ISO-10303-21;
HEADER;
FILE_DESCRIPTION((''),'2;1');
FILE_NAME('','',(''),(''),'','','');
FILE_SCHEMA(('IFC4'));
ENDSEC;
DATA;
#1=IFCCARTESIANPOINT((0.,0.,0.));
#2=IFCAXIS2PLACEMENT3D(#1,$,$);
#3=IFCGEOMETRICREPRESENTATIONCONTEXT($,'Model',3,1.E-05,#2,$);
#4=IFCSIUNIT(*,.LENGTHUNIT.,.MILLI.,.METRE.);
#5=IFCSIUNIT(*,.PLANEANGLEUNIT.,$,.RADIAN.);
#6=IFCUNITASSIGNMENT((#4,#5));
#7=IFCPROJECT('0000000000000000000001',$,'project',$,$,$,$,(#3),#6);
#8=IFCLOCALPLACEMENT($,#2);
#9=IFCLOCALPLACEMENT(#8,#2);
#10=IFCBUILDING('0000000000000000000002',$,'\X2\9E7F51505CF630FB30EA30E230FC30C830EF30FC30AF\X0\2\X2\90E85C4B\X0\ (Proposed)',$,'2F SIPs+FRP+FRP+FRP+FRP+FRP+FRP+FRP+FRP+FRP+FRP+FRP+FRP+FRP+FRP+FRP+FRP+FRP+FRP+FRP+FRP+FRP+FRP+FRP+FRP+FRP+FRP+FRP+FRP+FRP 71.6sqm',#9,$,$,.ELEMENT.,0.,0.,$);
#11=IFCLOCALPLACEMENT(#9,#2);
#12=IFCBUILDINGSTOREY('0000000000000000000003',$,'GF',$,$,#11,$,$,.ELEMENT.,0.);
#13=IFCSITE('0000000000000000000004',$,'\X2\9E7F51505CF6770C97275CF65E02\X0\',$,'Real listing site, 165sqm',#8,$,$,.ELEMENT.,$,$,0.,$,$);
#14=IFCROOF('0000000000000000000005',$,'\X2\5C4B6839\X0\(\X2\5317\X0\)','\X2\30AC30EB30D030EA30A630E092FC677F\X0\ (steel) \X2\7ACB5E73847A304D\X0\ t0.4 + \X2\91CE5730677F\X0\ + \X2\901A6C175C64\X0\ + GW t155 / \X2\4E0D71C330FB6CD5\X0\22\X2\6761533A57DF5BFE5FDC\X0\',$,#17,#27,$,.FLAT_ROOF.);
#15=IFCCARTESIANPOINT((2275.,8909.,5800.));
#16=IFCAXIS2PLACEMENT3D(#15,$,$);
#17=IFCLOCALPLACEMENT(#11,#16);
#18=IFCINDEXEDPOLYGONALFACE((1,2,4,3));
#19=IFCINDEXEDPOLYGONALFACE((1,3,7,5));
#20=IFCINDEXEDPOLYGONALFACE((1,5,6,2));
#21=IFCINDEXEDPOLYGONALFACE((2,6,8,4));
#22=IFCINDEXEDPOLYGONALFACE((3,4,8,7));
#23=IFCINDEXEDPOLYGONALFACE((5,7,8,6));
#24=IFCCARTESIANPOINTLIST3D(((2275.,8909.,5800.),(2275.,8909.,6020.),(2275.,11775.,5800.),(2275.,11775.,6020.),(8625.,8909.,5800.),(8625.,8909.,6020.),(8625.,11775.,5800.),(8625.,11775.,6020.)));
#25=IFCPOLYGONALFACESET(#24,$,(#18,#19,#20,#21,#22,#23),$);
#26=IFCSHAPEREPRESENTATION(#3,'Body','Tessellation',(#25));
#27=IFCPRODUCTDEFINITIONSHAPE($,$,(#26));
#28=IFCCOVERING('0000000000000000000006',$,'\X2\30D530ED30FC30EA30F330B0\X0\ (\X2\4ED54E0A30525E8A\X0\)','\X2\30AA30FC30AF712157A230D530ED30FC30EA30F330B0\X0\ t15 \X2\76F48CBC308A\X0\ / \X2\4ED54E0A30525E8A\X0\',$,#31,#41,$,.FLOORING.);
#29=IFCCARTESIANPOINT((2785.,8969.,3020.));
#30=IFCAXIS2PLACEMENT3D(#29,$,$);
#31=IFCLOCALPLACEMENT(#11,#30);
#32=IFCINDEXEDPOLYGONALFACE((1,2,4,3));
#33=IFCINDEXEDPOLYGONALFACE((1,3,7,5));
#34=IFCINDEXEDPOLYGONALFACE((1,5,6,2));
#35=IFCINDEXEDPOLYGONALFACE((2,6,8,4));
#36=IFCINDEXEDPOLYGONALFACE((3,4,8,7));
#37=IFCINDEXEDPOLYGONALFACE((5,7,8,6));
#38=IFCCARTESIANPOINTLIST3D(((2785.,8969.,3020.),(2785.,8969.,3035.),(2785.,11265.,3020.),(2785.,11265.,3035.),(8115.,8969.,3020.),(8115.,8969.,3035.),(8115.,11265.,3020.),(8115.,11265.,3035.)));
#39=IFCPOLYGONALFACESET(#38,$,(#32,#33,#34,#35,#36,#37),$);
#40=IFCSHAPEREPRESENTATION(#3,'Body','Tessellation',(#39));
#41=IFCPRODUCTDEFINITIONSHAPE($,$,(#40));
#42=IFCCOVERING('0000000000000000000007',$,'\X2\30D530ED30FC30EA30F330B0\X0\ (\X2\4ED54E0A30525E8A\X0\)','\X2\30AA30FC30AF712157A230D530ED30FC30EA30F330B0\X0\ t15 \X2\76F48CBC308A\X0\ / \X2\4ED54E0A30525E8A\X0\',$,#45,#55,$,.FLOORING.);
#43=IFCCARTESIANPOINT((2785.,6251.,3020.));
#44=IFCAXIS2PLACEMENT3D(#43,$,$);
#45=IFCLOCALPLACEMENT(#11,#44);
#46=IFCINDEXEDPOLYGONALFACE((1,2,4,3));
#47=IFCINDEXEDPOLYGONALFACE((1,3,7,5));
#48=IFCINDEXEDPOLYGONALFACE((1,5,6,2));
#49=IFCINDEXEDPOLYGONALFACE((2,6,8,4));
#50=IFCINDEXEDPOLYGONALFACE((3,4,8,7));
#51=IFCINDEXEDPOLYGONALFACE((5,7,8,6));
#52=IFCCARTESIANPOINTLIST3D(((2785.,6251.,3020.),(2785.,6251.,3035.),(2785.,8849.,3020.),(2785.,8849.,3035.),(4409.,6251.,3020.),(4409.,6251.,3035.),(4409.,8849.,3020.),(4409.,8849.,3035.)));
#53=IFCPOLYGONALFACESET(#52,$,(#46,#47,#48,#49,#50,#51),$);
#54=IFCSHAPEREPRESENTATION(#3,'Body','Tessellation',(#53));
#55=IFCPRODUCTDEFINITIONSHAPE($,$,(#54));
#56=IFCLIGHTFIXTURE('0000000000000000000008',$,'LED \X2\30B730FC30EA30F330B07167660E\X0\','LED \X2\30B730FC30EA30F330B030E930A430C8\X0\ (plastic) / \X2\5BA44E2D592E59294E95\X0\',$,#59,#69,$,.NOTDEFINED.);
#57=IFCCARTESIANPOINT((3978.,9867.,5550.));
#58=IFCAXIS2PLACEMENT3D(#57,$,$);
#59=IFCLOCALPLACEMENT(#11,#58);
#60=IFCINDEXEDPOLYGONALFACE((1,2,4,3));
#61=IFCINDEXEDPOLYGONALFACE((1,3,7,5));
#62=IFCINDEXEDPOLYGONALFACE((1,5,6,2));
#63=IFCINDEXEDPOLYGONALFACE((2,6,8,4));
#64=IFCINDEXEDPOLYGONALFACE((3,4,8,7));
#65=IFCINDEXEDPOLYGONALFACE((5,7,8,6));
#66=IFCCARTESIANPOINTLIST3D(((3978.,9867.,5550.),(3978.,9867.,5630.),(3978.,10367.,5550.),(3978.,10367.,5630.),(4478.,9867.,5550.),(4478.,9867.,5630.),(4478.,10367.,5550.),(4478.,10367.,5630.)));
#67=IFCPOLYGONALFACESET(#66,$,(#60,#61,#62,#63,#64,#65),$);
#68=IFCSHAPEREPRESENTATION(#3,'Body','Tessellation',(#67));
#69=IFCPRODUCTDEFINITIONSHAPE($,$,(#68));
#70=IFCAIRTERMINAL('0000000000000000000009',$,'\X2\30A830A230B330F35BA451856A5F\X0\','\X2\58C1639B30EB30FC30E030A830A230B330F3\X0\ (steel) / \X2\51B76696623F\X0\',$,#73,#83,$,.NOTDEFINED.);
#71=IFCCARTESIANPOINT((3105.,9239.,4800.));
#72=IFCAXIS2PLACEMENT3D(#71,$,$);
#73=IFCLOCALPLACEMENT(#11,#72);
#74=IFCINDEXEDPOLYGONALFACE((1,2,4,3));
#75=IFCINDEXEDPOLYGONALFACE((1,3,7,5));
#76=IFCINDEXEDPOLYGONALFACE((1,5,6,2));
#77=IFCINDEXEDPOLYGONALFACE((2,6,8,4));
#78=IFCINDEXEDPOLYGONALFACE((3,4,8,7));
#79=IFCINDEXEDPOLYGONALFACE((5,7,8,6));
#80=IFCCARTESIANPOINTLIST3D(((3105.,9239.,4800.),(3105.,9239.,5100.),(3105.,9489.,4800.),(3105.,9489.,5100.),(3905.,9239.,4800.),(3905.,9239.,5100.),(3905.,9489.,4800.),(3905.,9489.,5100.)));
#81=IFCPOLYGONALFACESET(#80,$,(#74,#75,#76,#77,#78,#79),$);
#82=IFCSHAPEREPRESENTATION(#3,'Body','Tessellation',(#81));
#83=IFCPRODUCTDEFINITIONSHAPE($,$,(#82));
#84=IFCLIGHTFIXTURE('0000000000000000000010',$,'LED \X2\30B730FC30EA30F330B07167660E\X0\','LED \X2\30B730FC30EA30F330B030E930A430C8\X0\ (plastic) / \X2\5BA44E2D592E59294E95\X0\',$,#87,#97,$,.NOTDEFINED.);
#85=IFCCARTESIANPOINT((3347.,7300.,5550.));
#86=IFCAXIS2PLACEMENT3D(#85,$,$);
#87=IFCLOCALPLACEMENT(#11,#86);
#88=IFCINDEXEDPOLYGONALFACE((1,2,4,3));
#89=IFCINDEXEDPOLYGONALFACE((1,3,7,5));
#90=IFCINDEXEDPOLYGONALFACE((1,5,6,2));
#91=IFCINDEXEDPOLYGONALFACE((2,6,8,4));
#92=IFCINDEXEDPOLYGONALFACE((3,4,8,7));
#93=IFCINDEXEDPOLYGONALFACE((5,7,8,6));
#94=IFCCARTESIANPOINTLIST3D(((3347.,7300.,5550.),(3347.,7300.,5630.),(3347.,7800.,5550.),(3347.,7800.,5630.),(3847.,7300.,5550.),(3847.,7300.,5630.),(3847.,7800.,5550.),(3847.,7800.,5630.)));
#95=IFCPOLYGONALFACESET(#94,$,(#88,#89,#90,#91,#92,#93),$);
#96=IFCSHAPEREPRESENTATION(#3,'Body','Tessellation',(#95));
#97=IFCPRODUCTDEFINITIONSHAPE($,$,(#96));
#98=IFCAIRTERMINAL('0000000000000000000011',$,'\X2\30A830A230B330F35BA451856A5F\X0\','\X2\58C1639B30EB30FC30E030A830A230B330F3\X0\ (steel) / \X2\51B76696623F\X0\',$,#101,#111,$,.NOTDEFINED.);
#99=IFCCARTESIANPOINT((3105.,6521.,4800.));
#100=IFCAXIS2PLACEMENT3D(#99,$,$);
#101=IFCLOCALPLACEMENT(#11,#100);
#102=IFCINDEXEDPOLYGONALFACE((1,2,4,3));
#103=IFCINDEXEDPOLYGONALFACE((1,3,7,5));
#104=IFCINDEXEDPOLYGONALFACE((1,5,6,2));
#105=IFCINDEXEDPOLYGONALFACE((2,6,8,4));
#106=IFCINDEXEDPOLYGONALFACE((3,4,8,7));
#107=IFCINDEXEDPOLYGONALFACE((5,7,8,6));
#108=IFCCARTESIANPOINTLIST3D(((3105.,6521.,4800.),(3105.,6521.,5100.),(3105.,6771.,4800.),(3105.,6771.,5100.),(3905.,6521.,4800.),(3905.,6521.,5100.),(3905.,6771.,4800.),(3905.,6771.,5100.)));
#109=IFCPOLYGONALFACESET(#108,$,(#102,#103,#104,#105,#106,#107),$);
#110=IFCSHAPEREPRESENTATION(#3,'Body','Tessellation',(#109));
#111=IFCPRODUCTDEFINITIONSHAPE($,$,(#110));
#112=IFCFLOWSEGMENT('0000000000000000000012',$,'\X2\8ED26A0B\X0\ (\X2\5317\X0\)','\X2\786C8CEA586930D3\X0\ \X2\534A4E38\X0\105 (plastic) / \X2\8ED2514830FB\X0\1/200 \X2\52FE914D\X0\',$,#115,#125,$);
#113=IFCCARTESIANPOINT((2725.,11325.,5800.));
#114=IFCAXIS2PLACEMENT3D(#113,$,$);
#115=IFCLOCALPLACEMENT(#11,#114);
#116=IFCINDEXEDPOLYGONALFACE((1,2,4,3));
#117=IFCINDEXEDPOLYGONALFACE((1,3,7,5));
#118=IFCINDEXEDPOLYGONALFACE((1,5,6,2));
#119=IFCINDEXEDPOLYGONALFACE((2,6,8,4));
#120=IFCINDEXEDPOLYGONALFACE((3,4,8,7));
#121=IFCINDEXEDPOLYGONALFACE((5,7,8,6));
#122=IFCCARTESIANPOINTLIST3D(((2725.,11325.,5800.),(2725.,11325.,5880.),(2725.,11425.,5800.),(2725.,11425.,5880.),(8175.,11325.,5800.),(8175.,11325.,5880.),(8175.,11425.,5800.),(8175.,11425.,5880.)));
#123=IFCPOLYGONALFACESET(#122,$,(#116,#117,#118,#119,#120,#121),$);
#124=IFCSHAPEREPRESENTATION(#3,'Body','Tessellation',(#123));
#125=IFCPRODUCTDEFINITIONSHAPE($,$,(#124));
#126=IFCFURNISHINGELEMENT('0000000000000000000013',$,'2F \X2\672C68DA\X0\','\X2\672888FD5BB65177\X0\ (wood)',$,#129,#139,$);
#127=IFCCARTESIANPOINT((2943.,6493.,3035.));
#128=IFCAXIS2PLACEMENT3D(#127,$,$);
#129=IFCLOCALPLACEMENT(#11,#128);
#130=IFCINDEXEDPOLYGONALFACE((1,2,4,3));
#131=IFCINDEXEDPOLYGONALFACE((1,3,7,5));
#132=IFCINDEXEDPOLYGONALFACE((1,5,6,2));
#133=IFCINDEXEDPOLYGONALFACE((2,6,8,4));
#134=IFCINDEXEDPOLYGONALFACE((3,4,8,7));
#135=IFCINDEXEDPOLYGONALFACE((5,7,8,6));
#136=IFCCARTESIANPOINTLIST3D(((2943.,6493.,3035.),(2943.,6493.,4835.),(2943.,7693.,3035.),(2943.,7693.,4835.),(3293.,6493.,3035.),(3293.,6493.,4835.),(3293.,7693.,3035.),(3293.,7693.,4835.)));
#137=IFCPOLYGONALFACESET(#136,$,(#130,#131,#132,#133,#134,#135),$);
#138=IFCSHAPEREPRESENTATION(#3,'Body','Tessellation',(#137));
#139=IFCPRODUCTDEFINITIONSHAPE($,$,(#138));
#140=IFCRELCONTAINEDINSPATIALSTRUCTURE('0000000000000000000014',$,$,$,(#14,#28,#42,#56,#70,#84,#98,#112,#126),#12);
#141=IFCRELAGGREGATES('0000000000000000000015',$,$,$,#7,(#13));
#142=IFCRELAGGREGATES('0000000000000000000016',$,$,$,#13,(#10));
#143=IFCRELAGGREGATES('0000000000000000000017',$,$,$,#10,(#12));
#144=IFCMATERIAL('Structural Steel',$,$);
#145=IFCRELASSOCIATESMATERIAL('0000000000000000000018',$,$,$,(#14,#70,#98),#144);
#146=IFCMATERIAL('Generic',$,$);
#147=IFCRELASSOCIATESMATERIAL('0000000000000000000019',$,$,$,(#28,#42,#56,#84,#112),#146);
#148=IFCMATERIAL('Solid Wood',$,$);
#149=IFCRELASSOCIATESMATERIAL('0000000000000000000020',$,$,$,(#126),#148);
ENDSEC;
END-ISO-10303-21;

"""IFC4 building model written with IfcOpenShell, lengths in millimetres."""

from ifc_helpers import new_model, si_unit, frame, frame_2d, origin, place, context, project, spatial, rectangle, extrude, material, element, save


model = new_model("IFC4")

# Units and contexts
model_context = context("Model", 3, precision=1e-05, world=origin())
ifc_project = project(units=[si_unit("LENGTHUNIT", "METRE", prefix="MILLI"), si_unit("PLANEANGLEUNIT", "RADIAN")], contexts=[model_context])

# Site, building, storey
site_placement = place(None, origin())
site = spatial("IfcSite", under=ifc_project, at=site_placement, Name="鹿児島県霧島市", ObjectType="Real listing site, 165sqm", CompositionType="ELEMENT", RefElevation=0.0)
building_placement = place(site_placement, origin())
building = spatial("IfcBuilding", under=site, at=building_placement, Name="鹿児島・リモートワーク2部屋 (Proposed)", ObjectType="2F SIPs+FRP+FRP+FRP+FRP+FRP+FRP+FRP+FRP+FRP+FRP+FRP+FRP+FRP+FRP+FRP+FRP+FRP+FRP+FRP+FRP+FRP+FRP+FRP+FRP+FRP+FRP+FRP+FRP+FRP 71.6sqm", CompositionType="ELEMENT", ElevationOfRefHeight=0.0, ElevationOfTerrain=0.0)
storey_placement = place(building_placement, origin())
storey = spatial("IfcBuildingStorey", under=building, at=storey_placement, Name="GF", CompositionType="ELEMENT", Elevation=0.0)

# Shared definitions
ifc_material_1 = material(Name="Solid Wood")

# Roof
ifc_material_2 = material(Name="Structural Steel")
for number, where, name in (
    (1, (2275.0, 8909.0, 5800.0), "屋根(北)"),
):
    element("IfcRoof", number, at=place(storey_placement, frame(where)), inside=storey, material=ifc_material_2, Name=name, Description="ガルバリウム鋼板 (steel) 立平葺き t0.4 + 野地板 + 通気層 + GW t155 / 不燃・法22条区域対応", PredefinedType="FLAT_ROOF", context=model_context, shape_type="SweptSolid", body=[
        extrude(rectangle(XDim=6350.0, YDim=2866.0, at=frame_2d((3175.0, 1433.0))), frame((2275.0, 8909.0, 5800.0)), (0.0, 0.0, 1.0), 220.0),
    ])

# Coverings
ifc_material_3 = material(Name="Generic")
covering_1_placement = place(storey_placement, frame((2785.0, 8969.0, 3020.0)))
element("IfcCovering", 2, at=covering_1_placement, inside=storey, material=ifc_material_3, Name="フローリング (仕上げ床)", Description="オーク無垢フローリング t15 直貼り / 仕上げ床", PredefinedType="FLOORING", context=model_context, shape_type="SweptSolid", body=[
    extrude(rectangle(XDim=5330.0, YDim=2296.0, at=frame_2d((2665.0, 1148.0))), frame((2785.0, 8969.0, 3020.0)), (0.0, 0.0, 1.0), 15.0),
])
covering_2_placement = place(storey_placement, frame((2785.0, 6251.0, 3020.0)))
element("IfcCovering", 3, at=covering_2_placement, inside=storey, material=ifc_material_3, Name="フローリング (仕上げ床)", Description="オーク無垢フローリング t15 直貼り / 仕上げ床", PredefinedType="FLOORING", context=model_context, shape_type="SweptSolid", body=[
    extrude(rectangle(XDim=1624.0, YDim=2598.0, at=frame_2d((812.0, 1299.0))), frame((2785.0, 6251.0, 3020.0)), (0.0, 0.0, 1.0), 15.0),
])

# Light fixture
light_fixture_1_placement = place(storey_placement, frame((3978.0, 9867.0, 5550.0)))
element("IfcLightFixture", 4, at=light_fixture_1_placement, inside=storey, material=ifc_material_3, Name="LED シーリング照明", Description="LED シーリングライト (plastic) / 室中央天井", PredefinedType="NOTDEFINED", context=model_context, shape_type="SweptSolid", body=[
    extrude(rectangle(XDim=500.0, YDim=500.0, at=frame_2d((250.0, 250.0))), frame((3978.0, 9867.0, 5550.0)), (0.0, 0.0, 1.0), 80.0),
])

# Air terminal
air_terminal_1_placement = place(storey_placement, frame((3105.0, 9239.0, 4800.0)))
element("IfcAirTerminal", 5, at=air_terminal_1_placement, inside=storey, material=ifc_material_2, Name="エアコン室内機", Description="壁掛ルームエアコン (steel) / 冷暖房", PredefinedType="NOTDEFINED", context=model_context, shape_type="SweptSolid", body=[
    extrude(rectangle(XDim=800.0, YDim=250.0, at=frame_2d((400.0, 125.0))), frame((3105.0, 9239.0, 4800.0)), (0.0, 0.0, 1.0), 300.0),
])

# Light fixture
light_fixture_2_placement = place(storey_placement, frame((3347.0, 7300.0, 5550.0)))
element("IfcLightFixture", 6, at=light_fixture_2_placement, inside=storey, material=ifc_material_3, Name="LED シーリング照明", Description="LED シーリングライト (plastic) / 室中央天井", PredefinedType="NOTDEFINED", context=model_context, shape_type="SweptSolid", body=[
    extrude(rectangle(XDim=500.0, YDim=500.0, at=frame_2d((250.0, 250.0))), frame((3347.0, 7300.0, 5550.0)), (0.0, 0.0, 1.0), 80.0),
])

# Air terminal
air_terminal_2_placement = place(storey_placement, frame((3105.0, 6521.0, 4800.0)))
element("IfcAirTerminal", 7, at=air_terminal_2_placement, inside=storey, material=ifc_material_2, Name="エアコン室内機", Description="壁掛ルームエアコン (steel) / 冷暖房", PredefinedType="NOTDEFINED", context=model_context, shape_type="SweptSolid", body=[
    extrude(rectangle(XDim=800.0, YDim=250.0, at=frame_2d((400.0, 125.0))), frame((3105.0, 6521.0, 4800.0)), (0.0, 0.0, 1.0), 300.0),
])

# Flow segment
flow_segment_placement = place(storey_placement, frame((2725.0, 11325.0, 5800.0)))
element("IfcFlowSegment", 8, at=flow_segment_placement, inside=storey, material=ifc_material_3, Name="軒樋 (北)", Description="硬質塩ビ 半丸105 (plastic) / 軒先・1/200 勾配", context=model_context, shape_type="SweptSolid", body=[
    extrude(rectangle(XDim=5450.0, YDim=100.0, at=frame_2d((2725.0, 50.0))), frame((2725.0, 11325.0, 5800.0)), (0.0, 0.0, 1.0), 80.0),
])

# Furnishing element
furnishing_placement = place(storey_placement, frame((2943.0, 6493.0, 3035.0)))
element("IfcFurnishingElement", 9, at=furnishing_placement, inside=storey, material=ifc_material_1, Name="2F 本棚", Description="木製家具 (wood)", context=model_context, shape_type="SweptSolid", body=[
    extrude(rectangle(XDim=350.0, YDim=1200.0, at=frame_2d((175.0, 600.0))), frame((2943.0, 6493.0, 3035.0)), (0.0, 0.0, 1.0), 1800.0),
])

save(model, "model.ifc")
